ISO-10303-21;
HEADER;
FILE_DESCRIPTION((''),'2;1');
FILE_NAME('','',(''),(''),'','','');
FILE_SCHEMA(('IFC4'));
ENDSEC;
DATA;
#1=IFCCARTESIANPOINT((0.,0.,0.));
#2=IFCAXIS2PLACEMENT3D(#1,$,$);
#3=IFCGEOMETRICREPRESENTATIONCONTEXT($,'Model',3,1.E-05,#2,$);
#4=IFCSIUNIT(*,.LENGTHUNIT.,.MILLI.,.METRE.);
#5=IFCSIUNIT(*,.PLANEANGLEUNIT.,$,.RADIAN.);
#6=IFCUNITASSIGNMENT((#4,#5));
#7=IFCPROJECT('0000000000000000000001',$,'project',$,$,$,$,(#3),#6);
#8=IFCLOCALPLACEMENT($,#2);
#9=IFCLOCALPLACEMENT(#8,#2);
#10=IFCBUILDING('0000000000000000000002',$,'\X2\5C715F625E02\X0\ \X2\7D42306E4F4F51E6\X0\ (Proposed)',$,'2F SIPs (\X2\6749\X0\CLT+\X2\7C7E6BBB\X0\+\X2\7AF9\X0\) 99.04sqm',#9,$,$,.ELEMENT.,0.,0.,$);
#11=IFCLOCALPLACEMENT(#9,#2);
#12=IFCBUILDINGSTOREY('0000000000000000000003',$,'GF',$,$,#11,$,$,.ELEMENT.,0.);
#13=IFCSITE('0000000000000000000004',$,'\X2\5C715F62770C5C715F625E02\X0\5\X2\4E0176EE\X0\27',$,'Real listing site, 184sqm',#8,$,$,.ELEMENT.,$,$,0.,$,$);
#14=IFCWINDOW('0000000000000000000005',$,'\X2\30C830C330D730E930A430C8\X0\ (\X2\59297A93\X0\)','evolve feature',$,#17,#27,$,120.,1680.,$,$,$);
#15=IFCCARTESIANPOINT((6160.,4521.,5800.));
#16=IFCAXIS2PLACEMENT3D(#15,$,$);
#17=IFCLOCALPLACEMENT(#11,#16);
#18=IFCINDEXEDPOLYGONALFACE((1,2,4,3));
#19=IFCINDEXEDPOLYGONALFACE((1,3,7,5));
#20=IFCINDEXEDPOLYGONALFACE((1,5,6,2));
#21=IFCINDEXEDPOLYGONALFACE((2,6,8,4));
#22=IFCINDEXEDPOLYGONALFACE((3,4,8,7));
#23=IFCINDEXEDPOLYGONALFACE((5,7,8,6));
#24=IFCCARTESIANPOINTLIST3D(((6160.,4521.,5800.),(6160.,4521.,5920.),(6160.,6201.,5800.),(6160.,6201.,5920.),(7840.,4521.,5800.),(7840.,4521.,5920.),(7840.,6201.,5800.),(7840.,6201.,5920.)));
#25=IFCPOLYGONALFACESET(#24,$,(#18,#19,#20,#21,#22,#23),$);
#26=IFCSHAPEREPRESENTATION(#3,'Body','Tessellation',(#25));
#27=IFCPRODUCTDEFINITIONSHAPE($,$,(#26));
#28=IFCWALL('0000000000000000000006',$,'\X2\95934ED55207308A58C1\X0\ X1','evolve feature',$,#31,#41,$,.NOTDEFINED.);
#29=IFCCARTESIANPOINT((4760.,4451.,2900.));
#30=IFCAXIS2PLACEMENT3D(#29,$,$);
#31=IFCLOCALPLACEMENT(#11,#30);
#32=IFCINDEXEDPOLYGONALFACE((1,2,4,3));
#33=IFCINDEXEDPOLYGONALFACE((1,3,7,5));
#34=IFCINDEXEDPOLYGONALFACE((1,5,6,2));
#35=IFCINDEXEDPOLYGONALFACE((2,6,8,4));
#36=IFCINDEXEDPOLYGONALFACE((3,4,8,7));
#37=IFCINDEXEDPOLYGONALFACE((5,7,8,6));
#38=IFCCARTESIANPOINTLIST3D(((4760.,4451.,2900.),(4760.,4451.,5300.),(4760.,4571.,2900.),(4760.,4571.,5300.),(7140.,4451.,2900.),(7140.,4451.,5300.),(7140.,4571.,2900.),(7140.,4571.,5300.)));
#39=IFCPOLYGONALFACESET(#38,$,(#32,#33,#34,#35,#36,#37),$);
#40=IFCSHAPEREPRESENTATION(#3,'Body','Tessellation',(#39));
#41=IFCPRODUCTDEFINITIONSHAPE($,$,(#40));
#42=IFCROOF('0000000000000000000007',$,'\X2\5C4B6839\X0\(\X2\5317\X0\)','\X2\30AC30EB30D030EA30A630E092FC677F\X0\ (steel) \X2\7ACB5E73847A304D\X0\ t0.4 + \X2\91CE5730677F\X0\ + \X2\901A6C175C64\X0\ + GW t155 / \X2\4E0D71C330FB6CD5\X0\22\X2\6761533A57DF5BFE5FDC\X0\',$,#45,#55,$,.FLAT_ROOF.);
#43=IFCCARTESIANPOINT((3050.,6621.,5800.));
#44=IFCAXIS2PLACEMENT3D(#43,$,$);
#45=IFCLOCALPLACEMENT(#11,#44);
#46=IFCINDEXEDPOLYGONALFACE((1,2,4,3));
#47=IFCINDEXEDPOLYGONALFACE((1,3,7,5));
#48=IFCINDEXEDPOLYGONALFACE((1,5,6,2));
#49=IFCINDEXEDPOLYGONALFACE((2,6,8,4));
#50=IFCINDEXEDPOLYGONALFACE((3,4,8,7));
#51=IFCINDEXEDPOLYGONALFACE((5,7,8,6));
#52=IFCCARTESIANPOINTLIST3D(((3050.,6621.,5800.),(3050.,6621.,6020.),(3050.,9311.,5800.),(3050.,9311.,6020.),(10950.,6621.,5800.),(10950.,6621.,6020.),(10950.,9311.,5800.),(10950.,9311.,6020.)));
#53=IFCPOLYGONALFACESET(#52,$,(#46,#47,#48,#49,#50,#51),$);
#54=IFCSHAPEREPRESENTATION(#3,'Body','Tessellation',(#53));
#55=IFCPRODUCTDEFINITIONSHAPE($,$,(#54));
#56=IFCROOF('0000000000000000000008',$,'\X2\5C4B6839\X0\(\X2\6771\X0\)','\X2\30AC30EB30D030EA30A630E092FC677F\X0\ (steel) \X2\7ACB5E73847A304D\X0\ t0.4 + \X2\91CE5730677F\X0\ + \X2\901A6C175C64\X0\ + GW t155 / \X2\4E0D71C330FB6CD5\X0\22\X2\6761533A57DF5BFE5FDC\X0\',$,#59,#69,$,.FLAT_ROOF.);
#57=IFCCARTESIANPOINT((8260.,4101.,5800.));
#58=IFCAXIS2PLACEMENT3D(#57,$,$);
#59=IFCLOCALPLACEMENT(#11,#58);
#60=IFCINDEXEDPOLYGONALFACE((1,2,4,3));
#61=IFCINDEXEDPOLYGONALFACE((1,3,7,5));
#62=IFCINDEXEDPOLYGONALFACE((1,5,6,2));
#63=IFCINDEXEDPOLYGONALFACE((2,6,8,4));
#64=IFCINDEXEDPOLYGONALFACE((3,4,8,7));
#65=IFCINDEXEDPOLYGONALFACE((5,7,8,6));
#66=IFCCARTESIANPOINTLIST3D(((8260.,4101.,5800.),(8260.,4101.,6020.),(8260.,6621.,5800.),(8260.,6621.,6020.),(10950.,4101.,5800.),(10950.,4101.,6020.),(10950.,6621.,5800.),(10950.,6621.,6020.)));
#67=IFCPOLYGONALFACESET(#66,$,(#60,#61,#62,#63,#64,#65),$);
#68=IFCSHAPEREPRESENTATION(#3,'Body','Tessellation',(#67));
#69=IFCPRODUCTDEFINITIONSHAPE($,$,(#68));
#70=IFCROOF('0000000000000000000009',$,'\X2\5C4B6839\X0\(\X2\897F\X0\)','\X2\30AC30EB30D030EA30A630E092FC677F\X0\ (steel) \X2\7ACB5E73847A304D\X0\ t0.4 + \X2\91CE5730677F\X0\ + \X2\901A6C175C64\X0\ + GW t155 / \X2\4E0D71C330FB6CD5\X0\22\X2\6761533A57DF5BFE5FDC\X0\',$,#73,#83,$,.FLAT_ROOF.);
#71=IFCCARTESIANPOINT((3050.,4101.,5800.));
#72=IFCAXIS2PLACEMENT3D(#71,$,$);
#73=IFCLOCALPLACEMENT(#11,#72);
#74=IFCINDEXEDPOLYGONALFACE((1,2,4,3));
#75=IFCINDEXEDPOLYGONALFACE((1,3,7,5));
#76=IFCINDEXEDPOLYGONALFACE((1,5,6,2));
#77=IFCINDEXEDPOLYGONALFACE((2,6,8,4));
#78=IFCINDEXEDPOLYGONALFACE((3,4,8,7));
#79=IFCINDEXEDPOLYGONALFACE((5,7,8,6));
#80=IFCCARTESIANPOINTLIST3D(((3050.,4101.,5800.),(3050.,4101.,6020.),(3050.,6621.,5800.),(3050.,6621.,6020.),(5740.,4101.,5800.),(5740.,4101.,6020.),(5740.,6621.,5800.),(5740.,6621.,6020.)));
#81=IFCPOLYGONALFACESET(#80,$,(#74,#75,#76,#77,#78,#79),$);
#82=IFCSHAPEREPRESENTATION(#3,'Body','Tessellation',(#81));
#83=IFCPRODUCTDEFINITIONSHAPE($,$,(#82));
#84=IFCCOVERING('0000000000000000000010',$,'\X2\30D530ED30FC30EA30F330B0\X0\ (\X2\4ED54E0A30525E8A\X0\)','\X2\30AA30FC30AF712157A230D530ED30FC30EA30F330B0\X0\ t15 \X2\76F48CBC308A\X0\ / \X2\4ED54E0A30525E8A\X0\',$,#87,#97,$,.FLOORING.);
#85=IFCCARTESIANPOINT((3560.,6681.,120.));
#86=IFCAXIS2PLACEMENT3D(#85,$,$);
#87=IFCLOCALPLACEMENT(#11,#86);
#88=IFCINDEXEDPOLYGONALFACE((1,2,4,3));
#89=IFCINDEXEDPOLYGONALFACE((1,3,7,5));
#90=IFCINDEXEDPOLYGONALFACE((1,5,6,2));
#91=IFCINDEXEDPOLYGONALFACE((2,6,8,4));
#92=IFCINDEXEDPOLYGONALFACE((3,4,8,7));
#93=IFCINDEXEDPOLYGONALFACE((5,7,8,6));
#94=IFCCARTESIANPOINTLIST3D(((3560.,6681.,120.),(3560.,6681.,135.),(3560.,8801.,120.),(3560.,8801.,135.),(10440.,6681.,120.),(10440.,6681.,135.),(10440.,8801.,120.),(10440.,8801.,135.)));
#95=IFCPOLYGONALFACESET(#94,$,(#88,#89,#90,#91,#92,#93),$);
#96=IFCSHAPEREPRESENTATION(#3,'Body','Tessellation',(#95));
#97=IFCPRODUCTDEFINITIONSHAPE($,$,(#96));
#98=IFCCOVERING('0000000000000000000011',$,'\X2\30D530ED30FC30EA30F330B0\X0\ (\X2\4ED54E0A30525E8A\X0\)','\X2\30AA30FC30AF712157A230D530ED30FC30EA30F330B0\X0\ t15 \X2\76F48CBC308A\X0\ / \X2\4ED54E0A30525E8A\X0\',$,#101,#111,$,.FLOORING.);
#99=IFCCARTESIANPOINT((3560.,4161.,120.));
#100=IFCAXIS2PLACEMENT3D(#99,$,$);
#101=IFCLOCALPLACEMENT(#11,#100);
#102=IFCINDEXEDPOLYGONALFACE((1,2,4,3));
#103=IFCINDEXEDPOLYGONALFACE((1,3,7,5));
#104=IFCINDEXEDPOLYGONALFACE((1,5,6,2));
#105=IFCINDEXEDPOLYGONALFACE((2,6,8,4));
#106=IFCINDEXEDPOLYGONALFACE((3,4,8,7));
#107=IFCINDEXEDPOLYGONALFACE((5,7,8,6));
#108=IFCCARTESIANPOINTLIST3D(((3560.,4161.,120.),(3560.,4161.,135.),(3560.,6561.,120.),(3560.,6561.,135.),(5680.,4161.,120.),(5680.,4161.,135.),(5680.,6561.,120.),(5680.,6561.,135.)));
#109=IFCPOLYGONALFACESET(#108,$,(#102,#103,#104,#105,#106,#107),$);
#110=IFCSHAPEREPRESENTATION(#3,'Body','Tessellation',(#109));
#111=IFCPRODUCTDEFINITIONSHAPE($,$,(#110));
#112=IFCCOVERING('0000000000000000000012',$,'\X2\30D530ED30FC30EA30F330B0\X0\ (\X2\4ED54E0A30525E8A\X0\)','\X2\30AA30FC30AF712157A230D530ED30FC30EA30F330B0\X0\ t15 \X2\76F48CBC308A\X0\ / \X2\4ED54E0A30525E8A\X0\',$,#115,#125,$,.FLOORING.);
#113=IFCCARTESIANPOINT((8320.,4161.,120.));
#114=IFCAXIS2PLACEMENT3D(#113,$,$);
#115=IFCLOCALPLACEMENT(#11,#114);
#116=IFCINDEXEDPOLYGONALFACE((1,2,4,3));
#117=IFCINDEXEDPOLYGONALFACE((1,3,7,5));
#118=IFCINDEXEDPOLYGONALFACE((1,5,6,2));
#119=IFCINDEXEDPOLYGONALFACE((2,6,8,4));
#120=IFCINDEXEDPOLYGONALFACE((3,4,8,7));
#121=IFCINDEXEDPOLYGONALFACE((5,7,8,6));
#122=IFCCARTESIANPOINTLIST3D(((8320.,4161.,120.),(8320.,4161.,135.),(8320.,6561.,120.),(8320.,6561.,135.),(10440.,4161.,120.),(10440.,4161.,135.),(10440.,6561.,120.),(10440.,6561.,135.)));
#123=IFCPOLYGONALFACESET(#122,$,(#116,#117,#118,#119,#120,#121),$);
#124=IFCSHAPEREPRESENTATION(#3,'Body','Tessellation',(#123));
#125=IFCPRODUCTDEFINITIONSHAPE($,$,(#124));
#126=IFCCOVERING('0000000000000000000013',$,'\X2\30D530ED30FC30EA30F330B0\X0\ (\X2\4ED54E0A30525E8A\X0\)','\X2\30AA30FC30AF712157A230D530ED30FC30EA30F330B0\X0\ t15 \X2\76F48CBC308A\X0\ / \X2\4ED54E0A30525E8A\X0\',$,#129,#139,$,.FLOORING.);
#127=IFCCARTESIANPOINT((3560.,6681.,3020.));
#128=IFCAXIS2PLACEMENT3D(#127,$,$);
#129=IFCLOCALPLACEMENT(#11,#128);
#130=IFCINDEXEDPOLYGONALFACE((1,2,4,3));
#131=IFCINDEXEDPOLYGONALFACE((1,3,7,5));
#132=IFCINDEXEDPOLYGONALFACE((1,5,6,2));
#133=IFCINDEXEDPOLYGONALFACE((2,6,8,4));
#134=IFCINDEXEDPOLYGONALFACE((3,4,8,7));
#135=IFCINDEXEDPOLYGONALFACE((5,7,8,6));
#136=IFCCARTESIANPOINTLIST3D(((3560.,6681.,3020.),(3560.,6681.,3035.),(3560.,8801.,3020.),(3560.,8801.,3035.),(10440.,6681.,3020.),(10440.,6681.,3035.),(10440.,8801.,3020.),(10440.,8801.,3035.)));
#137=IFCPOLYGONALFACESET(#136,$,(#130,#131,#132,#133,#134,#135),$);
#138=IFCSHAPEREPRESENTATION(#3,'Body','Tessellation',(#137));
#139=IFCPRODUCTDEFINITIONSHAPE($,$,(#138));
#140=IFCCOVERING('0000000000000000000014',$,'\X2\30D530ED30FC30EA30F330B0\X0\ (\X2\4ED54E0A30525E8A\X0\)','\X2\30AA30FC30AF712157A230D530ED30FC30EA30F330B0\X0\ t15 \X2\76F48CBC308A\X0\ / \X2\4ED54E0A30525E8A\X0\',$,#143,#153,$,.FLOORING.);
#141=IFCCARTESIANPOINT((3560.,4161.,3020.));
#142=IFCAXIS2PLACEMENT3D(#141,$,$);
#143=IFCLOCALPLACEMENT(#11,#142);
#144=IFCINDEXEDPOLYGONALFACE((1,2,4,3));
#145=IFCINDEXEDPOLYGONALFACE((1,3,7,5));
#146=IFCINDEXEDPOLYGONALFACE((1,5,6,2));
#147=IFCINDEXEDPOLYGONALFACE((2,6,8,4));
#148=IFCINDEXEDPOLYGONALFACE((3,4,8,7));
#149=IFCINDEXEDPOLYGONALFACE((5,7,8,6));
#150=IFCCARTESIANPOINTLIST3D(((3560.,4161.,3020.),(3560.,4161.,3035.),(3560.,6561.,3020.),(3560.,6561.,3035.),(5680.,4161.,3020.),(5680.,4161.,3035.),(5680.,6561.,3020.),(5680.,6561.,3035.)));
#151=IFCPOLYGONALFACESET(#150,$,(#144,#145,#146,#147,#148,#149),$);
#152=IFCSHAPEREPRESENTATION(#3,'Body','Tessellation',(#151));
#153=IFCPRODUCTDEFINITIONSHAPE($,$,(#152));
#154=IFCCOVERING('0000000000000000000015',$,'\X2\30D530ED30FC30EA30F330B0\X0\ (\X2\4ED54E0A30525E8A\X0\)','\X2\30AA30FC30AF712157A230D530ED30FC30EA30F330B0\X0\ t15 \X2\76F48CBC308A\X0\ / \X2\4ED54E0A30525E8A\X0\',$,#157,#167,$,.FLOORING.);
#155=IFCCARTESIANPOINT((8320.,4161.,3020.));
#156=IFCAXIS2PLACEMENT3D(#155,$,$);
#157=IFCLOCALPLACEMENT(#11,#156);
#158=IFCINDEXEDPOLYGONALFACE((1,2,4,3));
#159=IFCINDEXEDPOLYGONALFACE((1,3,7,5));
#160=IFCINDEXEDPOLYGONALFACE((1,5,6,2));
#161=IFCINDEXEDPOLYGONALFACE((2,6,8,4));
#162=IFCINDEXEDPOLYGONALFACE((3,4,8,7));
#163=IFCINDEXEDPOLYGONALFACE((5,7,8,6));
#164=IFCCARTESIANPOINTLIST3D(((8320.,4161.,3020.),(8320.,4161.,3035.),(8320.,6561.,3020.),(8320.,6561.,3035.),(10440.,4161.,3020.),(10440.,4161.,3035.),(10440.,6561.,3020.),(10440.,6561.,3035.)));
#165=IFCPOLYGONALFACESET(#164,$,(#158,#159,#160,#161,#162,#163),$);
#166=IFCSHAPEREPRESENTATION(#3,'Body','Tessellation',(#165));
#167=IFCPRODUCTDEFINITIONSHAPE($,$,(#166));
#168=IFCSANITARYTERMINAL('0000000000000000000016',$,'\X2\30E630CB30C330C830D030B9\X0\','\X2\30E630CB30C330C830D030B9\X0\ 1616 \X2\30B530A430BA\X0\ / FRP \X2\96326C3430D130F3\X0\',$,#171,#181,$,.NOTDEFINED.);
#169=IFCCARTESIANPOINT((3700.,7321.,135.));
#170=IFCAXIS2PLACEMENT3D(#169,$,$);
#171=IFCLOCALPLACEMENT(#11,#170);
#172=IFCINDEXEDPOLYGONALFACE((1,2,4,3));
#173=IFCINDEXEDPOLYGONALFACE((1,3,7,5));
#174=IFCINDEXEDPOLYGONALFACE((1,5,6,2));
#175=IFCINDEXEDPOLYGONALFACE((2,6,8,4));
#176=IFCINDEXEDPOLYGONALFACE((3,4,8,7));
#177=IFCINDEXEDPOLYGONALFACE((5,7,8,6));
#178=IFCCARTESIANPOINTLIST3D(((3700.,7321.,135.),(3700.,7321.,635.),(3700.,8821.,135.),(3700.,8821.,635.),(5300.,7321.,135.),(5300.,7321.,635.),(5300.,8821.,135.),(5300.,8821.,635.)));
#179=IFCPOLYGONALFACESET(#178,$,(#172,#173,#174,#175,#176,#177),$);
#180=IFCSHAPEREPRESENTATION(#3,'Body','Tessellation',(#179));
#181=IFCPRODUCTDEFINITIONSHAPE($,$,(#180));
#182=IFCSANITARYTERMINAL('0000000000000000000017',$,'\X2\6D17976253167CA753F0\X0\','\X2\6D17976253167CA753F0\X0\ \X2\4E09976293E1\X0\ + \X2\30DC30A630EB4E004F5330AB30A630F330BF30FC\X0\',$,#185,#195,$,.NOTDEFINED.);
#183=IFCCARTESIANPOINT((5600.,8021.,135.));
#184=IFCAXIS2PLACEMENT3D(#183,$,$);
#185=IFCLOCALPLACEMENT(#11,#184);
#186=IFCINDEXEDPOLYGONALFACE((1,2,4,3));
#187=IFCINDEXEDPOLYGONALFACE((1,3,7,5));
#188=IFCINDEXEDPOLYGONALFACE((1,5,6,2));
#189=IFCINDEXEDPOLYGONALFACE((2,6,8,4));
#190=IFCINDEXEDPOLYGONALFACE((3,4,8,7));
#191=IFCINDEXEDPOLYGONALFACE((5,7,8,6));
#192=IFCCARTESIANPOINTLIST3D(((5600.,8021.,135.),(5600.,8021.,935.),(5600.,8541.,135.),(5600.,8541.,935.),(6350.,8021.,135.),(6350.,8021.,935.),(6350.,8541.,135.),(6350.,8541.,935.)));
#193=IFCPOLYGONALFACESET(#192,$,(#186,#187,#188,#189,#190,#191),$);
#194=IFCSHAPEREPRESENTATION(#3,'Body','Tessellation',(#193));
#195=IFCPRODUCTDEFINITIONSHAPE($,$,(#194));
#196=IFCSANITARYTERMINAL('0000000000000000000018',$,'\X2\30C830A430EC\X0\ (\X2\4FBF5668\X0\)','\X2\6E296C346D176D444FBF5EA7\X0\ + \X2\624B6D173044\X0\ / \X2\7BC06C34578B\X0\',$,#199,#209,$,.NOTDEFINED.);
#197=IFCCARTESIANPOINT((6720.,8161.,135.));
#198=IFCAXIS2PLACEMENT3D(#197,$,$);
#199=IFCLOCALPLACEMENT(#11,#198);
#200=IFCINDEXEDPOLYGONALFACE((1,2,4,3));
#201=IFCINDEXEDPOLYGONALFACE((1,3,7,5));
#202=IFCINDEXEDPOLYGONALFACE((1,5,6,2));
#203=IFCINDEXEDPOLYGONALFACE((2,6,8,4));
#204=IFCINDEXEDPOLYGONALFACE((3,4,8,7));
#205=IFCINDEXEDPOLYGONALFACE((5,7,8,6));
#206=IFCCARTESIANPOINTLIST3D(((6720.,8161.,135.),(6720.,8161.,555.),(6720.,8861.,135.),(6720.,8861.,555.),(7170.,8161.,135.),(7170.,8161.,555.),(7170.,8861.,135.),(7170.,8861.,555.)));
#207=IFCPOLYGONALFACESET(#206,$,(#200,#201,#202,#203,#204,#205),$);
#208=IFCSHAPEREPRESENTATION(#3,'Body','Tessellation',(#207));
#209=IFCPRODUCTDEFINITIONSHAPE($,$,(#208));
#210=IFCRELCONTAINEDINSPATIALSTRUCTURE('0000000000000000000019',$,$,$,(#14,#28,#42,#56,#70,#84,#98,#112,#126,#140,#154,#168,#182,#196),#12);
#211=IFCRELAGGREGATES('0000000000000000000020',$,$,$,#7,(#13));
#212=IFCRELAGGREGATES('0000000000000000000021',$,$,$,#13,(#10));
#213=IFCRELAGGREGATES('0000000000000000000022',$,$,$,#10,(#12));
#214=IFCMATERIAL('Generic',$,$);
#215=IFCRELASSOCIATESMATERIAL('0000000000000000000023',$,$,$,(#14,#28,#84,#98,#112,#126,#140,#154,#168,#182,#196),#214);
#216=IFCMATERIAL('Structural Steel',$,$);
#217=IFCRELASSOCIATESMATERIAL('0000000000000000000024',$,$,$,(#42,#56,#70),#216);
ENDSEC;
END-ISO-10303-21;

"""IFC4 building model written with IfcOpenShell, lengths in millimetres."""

from ifc_helpers import new_model, si_unit, frame, frame_2d, origin, place, context, project, spatial, rectangle, extrude, material, element, save


model = new_model("IFC4")

# Units and contexts
model_context = context("Model", 3, precision=1e-05, world=origin())
ifc_project = project(units=[si_unit("LENGTHUNIT", "METRE", prefix="MILLI"), si_unit("PLANEANGLEUNIT", "RADIAN")], contexts=[model_context])

# Site, building, storey
site_placement = place(None, origin())
site = spatial("IfcSite", under=ifc_project, at=site_placement, Name="山形県山形市5丁目27", ObjectType="Real listing site, 184sqm", CompositionType="ELEMENT", RefElevation=0.0)
building_placement = place(site_placement, origin())
building = spatial("IfcBuilding", under=site, at=building_placement, Name="山形市 終の住処 (Proposed)", ObjectType="2F SIPs (杉CLT+籾殻+竹) 99.04sqm", CompositionType="ELEMENT", ElevationOfRefHeight=0.0, ElevationOfTerrain=0.0)
storey_placement = place(building_placement, origin())
storey = spatial("IfcBuildingStorey", under=building, at=storey_placement, Name="GF", CompositionType="ELEMENT", Elevation=0.0)

# Window
ifc_material_1 = material(Name="Generic")
window_1_placement = place(storey_placement, frame((6160.0, 4521.0, 5800.0)))
element("IfcWindow", 1, at=window_1_placement, inside=storey, material=ifc_material_1, Name="トップライト (天窓)", Description="evolve feature", OverallHeight=120.0, OverallWidth=1680.0, context=model_context, shape_type="SweptSolid", body=[
    extrude(rectangle(XDim=1680.0, YDim=1680.0, at=frame_2d((840.0, 840.0))), frame((6160.0, 4521.0, 5800.0)), (0.0, 0.0, 1.0), 120.0),
])

# Wall
wall_1_placement = place(storey_placement, frame((4760.0, 4451.0, 2900.0)))
element("IfcWall", 2, at=wall_1_placement, inside=storey, material=ifc_material_1, Name="間仕切り壁 X1", Description="evolve feature", PredefinedType="NOTDEFINED", context=model_context, shape_type="SweptSolid", body=[
    extrude(rectangle(XDim=2380.0, YDim=120.0, at=frame_2d((1190.0, 60.0))), frame((4760.0, 4451.0, 2900.0)), (0.0, 0.0, 1.0), 2400.0),
])

# Roofs
ifc_material_2 = material(Name="Structural Steel")
roof_1_placement = place(storey_placement, frame((3050.0, 6621.0, 5800.0)))
element("IfcRoof", 3, at=roof_1_placement, inside=storey, material=ifc_material_2, Name="屋根(北)", Description="ガルバリウム鋼板 (steel) 立平葺き t0.4 + 野地板 + 通気層 + GW t155 / 不燃・法22条区域対応", PredefinedType="FLAT_ROOF", context=model_context, shape_type="SweptSolid", body=[
    extrude(rectangle(XDim=7900.0, YDim=2690.0, at=frame_2d((3950.0, 1345.0))), frame((3050.0, 6621.0, 5800.0)), (0.0, 0.0, 1.0), 220.0),
])
roof_2_placement = place(storey_placement, frame((8260.0, 4101.0, 5800.0)))
element("IfcRoof", 4, at=roof_2_placement, inside=storey, material=ifc_material_2, Name="屋根(東)", Description="ガルバリウム鋼板 (steel) 立平葺き t0.4 + 野地板 + 通気層 + GW t155 / 不燃・法22条区域対応", PredefinedType="FLAT_ROOF", context=model_context, shape_type="SweptSolid", body=[
    extrude(rectangle(XDim=2690.0, YDim=2520.0, at=frame_2d((1345.0, 1260.0))), frame((8260.0, 4101.0, 5800.0)), (0.0, 0.0, 1.0), 220.0),
])
roof_3_placement = place(storey_placement, frame((3050.0, 4101.0, 5800.0)))
element("IfcRoof", 5, at=roof_3_placement, inside=storey, material=ifc_material_2, Name="屋根(西)", Description="ガルバリウム鋼板 (steel) 立平葺き t0.4 + 野地板 + 通気層 + GW t155 / 不燃・法22条区域対応", PredefinedType="FLAT_ROOF", context=model_context, shape_type="SweptSolid", body=[
    extrude(rectangle(XDim=2690.0, YDim=2520.0, at=frame_2d((1345.0, 1260.0))), frame((3050.0, 4101.0, 5800.0)), (0.0, 0.0, 1.0), 220.0),
])

# Coverings
covering_1_placement = place(storey_placement, frame((3560.0, 6681.0, 120.0)))
element("IfcCovering", 6, at=covering_1_placement, inside=storey, material=ifc_material_1, Name="フローリング (仕上げ床)", Description="オーク無垢フローリング t15 直貼り / 仕上げ床", PredefinedType="FLOORING", context=model_context, shape_type="SweptSolid", body=[
    extrude(rectangle(XDim=6880.0, YDim=2120.0, at=frame_2d((3440.0, 1060.0))), frame((3560.0, 6681.0, 120.0)), (0.0, 0.0, 1.0), 15.0),
])
covering_2_placement = place(storey_placement, frame((3560.0, 4161.0, 120.0)))
element("IfcCovering", 7, at=covering_2_placement, inside=storey, material=ifc_material_1, Name="フローリング (仕上げ床)", Description="オーク無垢フローリング t15 直貼り / 仕上げ床", PredefinedType="FLOORING", context=model_context, shape_type="SweptSolid", body=[
    extrude(rectangle(XDim=2120.0, YDim=2400.0, at=frame_2d((1060.0, 1200.0))), frame((3560.0, 4161.0, 120.0)), (0.0, 0.0, 1.0), 15.0),
])
covering_3_placement = place(storey_placement, frame((8320.0, 4161.0, 120.0)))
element("IfcCovering", 8, at=covering_3_placement, inside=storey, material=ifc_material_1, Name="フローリング (仕上げ床)", Description="オーク無垢フローリング t15 直貼り / 仕上げ床", PredefinedType="FLOORING", context=model_context, shape_type="SweptSolid", body=[
    extrude(rectangle(XDim=2120.0, YDim=2400.0, at=frame_2d((1060.0, 1200.0))), frame((8320.0, 4161.0, 120.0)), (0.0, 0.0, 1.0), 15.0),
])
covering_4_placement = place(storey_placement, frame((3560.0, 6681.0, 3020.0)))
element("IfcCovering", 9, at=covering_4_placement, inside=storey, material=ifc_material_1, Name="フローリング (仕上げ床)", Description="オーク無垢フローリング t15 直貼り / 仕上げ床", PredefinedType="FLOORING", context=model_context, shape_type="SweptSolid", body=[
    extrude(rectangle(XDim=6880.0, YDim=2120.0, at=frame_2d((3440.0, 1060.0))), frame((3560.0, 6681.0, 3020.0)), (0.0, 0.0, 1.0), 15.0),
])
covering_5_placement = place(storey_placement, frame((3560.0, 4161.0, 3020.0)))
element("IfcCovering", 10, at=covering_5_placement, inside=storey, material=ifc_material_1, Name="フローリング (仕上げ床)", Description="オーク無垢フローリング t15 直貼り / 仕上げ床", PredefinedType="FLOORING", context=model_context, shape_type="SweptSolid", body=[
    extrude(rectangle(XDim=2120.0, YDim=2400.0, at=frame_2d((1060.0, 1200.0))), frame((3560.0, 4161.0, 3020.0)), (0.0, 0.0, 1.0), 15.0),
])
covering_6_placement = place(storey_placement, frame((8320.0, 4161.0, 3020.0)))
element("IfcCovering", 11, at=covering_6_placement, inside=storey, material=ifc_material_1, Name="フローリング (仕上げ床)", Description="オーク無垢フローリング t15 直貼り / 仕上げ床", PredefinedType="FLOORING", context=model_context, shape_type="SweptSolid", body=[
    extrude(rectangle(XDim=2120.0, YDim=2400.0, at=frame_2d((1060.0, 1200.0))), frame((8320.0, 4161.0, 3020.0)), (0.0, 0.0, 1.0), 15.0),
])

# Sanitary terminals
sanitary_terminal_1_placement = place(storey_placement, frame((3700.0, 7321.0, 135.0)))
element("IfcSanitaryTerminal", 12, at=sanitary_terminal_1_placement, inside=storey, material=ifc_material_1, Name="ユニットバス", Description="ユニットバス 1616 サイズ / FRP 防水パン", PredefinedType="NOTDEFINED", context=model_context, shape_type="SweptSolid", body=[
    extrude(rectangle(XDim=1600.0, YDim=1500.0, at=frame_2d((800.0, 750.0))), frame((3700.0, 7321.0, 135.0)), (0.0, 0.0, 1.0), 500.0),
])
sanitary_terminal_2_placement = place(storey_placement, frame((5600.0, 8021.0, 135.0)))
element("IfcSanitaryTerminal", 13, at=sanitary_terminal_2_placement, inside=storey, material=ifc_material_1, Name="洗面化粧台", Description="洗面化粧台 三面鏡 + ボウル一体カウンター", PredefinedType="NOTDEFINED", context=model_context, shape_type="SweptSolid", body=[
    extrude(rectangle(XDim=750.0, YDim=520.0, at=frame_2d((375.0, 260.0))), frame((5600.0, 8021.0, 135.0)), (0.0, 0.0, 1.0), 800.0),
])
sanitary_terminal_3_placement = place(storey_placement, frame((6720.0, 8161.0, 135.0)))
element("IfcSanitaryTerminal", 14, at=sanitary_terminal_3_placement, inside=storey, material=ifc_material_1, Name="トイレ (便器)", Description="温水洗浄便座 + 手洗い / 節水型", PredefinedType="NOTDEFINED", context=model_context, shape_type="SweptSolid", body=[
    extrude(rectangle(XDim=450.0, YDim=700.0, at=frame_2d((225.0, 350.0))), frame((6720.0, 8161.0, 135.0)), (0.0, 0.0, 1.0), 420.0),
])

save(model, "model.ifc")
